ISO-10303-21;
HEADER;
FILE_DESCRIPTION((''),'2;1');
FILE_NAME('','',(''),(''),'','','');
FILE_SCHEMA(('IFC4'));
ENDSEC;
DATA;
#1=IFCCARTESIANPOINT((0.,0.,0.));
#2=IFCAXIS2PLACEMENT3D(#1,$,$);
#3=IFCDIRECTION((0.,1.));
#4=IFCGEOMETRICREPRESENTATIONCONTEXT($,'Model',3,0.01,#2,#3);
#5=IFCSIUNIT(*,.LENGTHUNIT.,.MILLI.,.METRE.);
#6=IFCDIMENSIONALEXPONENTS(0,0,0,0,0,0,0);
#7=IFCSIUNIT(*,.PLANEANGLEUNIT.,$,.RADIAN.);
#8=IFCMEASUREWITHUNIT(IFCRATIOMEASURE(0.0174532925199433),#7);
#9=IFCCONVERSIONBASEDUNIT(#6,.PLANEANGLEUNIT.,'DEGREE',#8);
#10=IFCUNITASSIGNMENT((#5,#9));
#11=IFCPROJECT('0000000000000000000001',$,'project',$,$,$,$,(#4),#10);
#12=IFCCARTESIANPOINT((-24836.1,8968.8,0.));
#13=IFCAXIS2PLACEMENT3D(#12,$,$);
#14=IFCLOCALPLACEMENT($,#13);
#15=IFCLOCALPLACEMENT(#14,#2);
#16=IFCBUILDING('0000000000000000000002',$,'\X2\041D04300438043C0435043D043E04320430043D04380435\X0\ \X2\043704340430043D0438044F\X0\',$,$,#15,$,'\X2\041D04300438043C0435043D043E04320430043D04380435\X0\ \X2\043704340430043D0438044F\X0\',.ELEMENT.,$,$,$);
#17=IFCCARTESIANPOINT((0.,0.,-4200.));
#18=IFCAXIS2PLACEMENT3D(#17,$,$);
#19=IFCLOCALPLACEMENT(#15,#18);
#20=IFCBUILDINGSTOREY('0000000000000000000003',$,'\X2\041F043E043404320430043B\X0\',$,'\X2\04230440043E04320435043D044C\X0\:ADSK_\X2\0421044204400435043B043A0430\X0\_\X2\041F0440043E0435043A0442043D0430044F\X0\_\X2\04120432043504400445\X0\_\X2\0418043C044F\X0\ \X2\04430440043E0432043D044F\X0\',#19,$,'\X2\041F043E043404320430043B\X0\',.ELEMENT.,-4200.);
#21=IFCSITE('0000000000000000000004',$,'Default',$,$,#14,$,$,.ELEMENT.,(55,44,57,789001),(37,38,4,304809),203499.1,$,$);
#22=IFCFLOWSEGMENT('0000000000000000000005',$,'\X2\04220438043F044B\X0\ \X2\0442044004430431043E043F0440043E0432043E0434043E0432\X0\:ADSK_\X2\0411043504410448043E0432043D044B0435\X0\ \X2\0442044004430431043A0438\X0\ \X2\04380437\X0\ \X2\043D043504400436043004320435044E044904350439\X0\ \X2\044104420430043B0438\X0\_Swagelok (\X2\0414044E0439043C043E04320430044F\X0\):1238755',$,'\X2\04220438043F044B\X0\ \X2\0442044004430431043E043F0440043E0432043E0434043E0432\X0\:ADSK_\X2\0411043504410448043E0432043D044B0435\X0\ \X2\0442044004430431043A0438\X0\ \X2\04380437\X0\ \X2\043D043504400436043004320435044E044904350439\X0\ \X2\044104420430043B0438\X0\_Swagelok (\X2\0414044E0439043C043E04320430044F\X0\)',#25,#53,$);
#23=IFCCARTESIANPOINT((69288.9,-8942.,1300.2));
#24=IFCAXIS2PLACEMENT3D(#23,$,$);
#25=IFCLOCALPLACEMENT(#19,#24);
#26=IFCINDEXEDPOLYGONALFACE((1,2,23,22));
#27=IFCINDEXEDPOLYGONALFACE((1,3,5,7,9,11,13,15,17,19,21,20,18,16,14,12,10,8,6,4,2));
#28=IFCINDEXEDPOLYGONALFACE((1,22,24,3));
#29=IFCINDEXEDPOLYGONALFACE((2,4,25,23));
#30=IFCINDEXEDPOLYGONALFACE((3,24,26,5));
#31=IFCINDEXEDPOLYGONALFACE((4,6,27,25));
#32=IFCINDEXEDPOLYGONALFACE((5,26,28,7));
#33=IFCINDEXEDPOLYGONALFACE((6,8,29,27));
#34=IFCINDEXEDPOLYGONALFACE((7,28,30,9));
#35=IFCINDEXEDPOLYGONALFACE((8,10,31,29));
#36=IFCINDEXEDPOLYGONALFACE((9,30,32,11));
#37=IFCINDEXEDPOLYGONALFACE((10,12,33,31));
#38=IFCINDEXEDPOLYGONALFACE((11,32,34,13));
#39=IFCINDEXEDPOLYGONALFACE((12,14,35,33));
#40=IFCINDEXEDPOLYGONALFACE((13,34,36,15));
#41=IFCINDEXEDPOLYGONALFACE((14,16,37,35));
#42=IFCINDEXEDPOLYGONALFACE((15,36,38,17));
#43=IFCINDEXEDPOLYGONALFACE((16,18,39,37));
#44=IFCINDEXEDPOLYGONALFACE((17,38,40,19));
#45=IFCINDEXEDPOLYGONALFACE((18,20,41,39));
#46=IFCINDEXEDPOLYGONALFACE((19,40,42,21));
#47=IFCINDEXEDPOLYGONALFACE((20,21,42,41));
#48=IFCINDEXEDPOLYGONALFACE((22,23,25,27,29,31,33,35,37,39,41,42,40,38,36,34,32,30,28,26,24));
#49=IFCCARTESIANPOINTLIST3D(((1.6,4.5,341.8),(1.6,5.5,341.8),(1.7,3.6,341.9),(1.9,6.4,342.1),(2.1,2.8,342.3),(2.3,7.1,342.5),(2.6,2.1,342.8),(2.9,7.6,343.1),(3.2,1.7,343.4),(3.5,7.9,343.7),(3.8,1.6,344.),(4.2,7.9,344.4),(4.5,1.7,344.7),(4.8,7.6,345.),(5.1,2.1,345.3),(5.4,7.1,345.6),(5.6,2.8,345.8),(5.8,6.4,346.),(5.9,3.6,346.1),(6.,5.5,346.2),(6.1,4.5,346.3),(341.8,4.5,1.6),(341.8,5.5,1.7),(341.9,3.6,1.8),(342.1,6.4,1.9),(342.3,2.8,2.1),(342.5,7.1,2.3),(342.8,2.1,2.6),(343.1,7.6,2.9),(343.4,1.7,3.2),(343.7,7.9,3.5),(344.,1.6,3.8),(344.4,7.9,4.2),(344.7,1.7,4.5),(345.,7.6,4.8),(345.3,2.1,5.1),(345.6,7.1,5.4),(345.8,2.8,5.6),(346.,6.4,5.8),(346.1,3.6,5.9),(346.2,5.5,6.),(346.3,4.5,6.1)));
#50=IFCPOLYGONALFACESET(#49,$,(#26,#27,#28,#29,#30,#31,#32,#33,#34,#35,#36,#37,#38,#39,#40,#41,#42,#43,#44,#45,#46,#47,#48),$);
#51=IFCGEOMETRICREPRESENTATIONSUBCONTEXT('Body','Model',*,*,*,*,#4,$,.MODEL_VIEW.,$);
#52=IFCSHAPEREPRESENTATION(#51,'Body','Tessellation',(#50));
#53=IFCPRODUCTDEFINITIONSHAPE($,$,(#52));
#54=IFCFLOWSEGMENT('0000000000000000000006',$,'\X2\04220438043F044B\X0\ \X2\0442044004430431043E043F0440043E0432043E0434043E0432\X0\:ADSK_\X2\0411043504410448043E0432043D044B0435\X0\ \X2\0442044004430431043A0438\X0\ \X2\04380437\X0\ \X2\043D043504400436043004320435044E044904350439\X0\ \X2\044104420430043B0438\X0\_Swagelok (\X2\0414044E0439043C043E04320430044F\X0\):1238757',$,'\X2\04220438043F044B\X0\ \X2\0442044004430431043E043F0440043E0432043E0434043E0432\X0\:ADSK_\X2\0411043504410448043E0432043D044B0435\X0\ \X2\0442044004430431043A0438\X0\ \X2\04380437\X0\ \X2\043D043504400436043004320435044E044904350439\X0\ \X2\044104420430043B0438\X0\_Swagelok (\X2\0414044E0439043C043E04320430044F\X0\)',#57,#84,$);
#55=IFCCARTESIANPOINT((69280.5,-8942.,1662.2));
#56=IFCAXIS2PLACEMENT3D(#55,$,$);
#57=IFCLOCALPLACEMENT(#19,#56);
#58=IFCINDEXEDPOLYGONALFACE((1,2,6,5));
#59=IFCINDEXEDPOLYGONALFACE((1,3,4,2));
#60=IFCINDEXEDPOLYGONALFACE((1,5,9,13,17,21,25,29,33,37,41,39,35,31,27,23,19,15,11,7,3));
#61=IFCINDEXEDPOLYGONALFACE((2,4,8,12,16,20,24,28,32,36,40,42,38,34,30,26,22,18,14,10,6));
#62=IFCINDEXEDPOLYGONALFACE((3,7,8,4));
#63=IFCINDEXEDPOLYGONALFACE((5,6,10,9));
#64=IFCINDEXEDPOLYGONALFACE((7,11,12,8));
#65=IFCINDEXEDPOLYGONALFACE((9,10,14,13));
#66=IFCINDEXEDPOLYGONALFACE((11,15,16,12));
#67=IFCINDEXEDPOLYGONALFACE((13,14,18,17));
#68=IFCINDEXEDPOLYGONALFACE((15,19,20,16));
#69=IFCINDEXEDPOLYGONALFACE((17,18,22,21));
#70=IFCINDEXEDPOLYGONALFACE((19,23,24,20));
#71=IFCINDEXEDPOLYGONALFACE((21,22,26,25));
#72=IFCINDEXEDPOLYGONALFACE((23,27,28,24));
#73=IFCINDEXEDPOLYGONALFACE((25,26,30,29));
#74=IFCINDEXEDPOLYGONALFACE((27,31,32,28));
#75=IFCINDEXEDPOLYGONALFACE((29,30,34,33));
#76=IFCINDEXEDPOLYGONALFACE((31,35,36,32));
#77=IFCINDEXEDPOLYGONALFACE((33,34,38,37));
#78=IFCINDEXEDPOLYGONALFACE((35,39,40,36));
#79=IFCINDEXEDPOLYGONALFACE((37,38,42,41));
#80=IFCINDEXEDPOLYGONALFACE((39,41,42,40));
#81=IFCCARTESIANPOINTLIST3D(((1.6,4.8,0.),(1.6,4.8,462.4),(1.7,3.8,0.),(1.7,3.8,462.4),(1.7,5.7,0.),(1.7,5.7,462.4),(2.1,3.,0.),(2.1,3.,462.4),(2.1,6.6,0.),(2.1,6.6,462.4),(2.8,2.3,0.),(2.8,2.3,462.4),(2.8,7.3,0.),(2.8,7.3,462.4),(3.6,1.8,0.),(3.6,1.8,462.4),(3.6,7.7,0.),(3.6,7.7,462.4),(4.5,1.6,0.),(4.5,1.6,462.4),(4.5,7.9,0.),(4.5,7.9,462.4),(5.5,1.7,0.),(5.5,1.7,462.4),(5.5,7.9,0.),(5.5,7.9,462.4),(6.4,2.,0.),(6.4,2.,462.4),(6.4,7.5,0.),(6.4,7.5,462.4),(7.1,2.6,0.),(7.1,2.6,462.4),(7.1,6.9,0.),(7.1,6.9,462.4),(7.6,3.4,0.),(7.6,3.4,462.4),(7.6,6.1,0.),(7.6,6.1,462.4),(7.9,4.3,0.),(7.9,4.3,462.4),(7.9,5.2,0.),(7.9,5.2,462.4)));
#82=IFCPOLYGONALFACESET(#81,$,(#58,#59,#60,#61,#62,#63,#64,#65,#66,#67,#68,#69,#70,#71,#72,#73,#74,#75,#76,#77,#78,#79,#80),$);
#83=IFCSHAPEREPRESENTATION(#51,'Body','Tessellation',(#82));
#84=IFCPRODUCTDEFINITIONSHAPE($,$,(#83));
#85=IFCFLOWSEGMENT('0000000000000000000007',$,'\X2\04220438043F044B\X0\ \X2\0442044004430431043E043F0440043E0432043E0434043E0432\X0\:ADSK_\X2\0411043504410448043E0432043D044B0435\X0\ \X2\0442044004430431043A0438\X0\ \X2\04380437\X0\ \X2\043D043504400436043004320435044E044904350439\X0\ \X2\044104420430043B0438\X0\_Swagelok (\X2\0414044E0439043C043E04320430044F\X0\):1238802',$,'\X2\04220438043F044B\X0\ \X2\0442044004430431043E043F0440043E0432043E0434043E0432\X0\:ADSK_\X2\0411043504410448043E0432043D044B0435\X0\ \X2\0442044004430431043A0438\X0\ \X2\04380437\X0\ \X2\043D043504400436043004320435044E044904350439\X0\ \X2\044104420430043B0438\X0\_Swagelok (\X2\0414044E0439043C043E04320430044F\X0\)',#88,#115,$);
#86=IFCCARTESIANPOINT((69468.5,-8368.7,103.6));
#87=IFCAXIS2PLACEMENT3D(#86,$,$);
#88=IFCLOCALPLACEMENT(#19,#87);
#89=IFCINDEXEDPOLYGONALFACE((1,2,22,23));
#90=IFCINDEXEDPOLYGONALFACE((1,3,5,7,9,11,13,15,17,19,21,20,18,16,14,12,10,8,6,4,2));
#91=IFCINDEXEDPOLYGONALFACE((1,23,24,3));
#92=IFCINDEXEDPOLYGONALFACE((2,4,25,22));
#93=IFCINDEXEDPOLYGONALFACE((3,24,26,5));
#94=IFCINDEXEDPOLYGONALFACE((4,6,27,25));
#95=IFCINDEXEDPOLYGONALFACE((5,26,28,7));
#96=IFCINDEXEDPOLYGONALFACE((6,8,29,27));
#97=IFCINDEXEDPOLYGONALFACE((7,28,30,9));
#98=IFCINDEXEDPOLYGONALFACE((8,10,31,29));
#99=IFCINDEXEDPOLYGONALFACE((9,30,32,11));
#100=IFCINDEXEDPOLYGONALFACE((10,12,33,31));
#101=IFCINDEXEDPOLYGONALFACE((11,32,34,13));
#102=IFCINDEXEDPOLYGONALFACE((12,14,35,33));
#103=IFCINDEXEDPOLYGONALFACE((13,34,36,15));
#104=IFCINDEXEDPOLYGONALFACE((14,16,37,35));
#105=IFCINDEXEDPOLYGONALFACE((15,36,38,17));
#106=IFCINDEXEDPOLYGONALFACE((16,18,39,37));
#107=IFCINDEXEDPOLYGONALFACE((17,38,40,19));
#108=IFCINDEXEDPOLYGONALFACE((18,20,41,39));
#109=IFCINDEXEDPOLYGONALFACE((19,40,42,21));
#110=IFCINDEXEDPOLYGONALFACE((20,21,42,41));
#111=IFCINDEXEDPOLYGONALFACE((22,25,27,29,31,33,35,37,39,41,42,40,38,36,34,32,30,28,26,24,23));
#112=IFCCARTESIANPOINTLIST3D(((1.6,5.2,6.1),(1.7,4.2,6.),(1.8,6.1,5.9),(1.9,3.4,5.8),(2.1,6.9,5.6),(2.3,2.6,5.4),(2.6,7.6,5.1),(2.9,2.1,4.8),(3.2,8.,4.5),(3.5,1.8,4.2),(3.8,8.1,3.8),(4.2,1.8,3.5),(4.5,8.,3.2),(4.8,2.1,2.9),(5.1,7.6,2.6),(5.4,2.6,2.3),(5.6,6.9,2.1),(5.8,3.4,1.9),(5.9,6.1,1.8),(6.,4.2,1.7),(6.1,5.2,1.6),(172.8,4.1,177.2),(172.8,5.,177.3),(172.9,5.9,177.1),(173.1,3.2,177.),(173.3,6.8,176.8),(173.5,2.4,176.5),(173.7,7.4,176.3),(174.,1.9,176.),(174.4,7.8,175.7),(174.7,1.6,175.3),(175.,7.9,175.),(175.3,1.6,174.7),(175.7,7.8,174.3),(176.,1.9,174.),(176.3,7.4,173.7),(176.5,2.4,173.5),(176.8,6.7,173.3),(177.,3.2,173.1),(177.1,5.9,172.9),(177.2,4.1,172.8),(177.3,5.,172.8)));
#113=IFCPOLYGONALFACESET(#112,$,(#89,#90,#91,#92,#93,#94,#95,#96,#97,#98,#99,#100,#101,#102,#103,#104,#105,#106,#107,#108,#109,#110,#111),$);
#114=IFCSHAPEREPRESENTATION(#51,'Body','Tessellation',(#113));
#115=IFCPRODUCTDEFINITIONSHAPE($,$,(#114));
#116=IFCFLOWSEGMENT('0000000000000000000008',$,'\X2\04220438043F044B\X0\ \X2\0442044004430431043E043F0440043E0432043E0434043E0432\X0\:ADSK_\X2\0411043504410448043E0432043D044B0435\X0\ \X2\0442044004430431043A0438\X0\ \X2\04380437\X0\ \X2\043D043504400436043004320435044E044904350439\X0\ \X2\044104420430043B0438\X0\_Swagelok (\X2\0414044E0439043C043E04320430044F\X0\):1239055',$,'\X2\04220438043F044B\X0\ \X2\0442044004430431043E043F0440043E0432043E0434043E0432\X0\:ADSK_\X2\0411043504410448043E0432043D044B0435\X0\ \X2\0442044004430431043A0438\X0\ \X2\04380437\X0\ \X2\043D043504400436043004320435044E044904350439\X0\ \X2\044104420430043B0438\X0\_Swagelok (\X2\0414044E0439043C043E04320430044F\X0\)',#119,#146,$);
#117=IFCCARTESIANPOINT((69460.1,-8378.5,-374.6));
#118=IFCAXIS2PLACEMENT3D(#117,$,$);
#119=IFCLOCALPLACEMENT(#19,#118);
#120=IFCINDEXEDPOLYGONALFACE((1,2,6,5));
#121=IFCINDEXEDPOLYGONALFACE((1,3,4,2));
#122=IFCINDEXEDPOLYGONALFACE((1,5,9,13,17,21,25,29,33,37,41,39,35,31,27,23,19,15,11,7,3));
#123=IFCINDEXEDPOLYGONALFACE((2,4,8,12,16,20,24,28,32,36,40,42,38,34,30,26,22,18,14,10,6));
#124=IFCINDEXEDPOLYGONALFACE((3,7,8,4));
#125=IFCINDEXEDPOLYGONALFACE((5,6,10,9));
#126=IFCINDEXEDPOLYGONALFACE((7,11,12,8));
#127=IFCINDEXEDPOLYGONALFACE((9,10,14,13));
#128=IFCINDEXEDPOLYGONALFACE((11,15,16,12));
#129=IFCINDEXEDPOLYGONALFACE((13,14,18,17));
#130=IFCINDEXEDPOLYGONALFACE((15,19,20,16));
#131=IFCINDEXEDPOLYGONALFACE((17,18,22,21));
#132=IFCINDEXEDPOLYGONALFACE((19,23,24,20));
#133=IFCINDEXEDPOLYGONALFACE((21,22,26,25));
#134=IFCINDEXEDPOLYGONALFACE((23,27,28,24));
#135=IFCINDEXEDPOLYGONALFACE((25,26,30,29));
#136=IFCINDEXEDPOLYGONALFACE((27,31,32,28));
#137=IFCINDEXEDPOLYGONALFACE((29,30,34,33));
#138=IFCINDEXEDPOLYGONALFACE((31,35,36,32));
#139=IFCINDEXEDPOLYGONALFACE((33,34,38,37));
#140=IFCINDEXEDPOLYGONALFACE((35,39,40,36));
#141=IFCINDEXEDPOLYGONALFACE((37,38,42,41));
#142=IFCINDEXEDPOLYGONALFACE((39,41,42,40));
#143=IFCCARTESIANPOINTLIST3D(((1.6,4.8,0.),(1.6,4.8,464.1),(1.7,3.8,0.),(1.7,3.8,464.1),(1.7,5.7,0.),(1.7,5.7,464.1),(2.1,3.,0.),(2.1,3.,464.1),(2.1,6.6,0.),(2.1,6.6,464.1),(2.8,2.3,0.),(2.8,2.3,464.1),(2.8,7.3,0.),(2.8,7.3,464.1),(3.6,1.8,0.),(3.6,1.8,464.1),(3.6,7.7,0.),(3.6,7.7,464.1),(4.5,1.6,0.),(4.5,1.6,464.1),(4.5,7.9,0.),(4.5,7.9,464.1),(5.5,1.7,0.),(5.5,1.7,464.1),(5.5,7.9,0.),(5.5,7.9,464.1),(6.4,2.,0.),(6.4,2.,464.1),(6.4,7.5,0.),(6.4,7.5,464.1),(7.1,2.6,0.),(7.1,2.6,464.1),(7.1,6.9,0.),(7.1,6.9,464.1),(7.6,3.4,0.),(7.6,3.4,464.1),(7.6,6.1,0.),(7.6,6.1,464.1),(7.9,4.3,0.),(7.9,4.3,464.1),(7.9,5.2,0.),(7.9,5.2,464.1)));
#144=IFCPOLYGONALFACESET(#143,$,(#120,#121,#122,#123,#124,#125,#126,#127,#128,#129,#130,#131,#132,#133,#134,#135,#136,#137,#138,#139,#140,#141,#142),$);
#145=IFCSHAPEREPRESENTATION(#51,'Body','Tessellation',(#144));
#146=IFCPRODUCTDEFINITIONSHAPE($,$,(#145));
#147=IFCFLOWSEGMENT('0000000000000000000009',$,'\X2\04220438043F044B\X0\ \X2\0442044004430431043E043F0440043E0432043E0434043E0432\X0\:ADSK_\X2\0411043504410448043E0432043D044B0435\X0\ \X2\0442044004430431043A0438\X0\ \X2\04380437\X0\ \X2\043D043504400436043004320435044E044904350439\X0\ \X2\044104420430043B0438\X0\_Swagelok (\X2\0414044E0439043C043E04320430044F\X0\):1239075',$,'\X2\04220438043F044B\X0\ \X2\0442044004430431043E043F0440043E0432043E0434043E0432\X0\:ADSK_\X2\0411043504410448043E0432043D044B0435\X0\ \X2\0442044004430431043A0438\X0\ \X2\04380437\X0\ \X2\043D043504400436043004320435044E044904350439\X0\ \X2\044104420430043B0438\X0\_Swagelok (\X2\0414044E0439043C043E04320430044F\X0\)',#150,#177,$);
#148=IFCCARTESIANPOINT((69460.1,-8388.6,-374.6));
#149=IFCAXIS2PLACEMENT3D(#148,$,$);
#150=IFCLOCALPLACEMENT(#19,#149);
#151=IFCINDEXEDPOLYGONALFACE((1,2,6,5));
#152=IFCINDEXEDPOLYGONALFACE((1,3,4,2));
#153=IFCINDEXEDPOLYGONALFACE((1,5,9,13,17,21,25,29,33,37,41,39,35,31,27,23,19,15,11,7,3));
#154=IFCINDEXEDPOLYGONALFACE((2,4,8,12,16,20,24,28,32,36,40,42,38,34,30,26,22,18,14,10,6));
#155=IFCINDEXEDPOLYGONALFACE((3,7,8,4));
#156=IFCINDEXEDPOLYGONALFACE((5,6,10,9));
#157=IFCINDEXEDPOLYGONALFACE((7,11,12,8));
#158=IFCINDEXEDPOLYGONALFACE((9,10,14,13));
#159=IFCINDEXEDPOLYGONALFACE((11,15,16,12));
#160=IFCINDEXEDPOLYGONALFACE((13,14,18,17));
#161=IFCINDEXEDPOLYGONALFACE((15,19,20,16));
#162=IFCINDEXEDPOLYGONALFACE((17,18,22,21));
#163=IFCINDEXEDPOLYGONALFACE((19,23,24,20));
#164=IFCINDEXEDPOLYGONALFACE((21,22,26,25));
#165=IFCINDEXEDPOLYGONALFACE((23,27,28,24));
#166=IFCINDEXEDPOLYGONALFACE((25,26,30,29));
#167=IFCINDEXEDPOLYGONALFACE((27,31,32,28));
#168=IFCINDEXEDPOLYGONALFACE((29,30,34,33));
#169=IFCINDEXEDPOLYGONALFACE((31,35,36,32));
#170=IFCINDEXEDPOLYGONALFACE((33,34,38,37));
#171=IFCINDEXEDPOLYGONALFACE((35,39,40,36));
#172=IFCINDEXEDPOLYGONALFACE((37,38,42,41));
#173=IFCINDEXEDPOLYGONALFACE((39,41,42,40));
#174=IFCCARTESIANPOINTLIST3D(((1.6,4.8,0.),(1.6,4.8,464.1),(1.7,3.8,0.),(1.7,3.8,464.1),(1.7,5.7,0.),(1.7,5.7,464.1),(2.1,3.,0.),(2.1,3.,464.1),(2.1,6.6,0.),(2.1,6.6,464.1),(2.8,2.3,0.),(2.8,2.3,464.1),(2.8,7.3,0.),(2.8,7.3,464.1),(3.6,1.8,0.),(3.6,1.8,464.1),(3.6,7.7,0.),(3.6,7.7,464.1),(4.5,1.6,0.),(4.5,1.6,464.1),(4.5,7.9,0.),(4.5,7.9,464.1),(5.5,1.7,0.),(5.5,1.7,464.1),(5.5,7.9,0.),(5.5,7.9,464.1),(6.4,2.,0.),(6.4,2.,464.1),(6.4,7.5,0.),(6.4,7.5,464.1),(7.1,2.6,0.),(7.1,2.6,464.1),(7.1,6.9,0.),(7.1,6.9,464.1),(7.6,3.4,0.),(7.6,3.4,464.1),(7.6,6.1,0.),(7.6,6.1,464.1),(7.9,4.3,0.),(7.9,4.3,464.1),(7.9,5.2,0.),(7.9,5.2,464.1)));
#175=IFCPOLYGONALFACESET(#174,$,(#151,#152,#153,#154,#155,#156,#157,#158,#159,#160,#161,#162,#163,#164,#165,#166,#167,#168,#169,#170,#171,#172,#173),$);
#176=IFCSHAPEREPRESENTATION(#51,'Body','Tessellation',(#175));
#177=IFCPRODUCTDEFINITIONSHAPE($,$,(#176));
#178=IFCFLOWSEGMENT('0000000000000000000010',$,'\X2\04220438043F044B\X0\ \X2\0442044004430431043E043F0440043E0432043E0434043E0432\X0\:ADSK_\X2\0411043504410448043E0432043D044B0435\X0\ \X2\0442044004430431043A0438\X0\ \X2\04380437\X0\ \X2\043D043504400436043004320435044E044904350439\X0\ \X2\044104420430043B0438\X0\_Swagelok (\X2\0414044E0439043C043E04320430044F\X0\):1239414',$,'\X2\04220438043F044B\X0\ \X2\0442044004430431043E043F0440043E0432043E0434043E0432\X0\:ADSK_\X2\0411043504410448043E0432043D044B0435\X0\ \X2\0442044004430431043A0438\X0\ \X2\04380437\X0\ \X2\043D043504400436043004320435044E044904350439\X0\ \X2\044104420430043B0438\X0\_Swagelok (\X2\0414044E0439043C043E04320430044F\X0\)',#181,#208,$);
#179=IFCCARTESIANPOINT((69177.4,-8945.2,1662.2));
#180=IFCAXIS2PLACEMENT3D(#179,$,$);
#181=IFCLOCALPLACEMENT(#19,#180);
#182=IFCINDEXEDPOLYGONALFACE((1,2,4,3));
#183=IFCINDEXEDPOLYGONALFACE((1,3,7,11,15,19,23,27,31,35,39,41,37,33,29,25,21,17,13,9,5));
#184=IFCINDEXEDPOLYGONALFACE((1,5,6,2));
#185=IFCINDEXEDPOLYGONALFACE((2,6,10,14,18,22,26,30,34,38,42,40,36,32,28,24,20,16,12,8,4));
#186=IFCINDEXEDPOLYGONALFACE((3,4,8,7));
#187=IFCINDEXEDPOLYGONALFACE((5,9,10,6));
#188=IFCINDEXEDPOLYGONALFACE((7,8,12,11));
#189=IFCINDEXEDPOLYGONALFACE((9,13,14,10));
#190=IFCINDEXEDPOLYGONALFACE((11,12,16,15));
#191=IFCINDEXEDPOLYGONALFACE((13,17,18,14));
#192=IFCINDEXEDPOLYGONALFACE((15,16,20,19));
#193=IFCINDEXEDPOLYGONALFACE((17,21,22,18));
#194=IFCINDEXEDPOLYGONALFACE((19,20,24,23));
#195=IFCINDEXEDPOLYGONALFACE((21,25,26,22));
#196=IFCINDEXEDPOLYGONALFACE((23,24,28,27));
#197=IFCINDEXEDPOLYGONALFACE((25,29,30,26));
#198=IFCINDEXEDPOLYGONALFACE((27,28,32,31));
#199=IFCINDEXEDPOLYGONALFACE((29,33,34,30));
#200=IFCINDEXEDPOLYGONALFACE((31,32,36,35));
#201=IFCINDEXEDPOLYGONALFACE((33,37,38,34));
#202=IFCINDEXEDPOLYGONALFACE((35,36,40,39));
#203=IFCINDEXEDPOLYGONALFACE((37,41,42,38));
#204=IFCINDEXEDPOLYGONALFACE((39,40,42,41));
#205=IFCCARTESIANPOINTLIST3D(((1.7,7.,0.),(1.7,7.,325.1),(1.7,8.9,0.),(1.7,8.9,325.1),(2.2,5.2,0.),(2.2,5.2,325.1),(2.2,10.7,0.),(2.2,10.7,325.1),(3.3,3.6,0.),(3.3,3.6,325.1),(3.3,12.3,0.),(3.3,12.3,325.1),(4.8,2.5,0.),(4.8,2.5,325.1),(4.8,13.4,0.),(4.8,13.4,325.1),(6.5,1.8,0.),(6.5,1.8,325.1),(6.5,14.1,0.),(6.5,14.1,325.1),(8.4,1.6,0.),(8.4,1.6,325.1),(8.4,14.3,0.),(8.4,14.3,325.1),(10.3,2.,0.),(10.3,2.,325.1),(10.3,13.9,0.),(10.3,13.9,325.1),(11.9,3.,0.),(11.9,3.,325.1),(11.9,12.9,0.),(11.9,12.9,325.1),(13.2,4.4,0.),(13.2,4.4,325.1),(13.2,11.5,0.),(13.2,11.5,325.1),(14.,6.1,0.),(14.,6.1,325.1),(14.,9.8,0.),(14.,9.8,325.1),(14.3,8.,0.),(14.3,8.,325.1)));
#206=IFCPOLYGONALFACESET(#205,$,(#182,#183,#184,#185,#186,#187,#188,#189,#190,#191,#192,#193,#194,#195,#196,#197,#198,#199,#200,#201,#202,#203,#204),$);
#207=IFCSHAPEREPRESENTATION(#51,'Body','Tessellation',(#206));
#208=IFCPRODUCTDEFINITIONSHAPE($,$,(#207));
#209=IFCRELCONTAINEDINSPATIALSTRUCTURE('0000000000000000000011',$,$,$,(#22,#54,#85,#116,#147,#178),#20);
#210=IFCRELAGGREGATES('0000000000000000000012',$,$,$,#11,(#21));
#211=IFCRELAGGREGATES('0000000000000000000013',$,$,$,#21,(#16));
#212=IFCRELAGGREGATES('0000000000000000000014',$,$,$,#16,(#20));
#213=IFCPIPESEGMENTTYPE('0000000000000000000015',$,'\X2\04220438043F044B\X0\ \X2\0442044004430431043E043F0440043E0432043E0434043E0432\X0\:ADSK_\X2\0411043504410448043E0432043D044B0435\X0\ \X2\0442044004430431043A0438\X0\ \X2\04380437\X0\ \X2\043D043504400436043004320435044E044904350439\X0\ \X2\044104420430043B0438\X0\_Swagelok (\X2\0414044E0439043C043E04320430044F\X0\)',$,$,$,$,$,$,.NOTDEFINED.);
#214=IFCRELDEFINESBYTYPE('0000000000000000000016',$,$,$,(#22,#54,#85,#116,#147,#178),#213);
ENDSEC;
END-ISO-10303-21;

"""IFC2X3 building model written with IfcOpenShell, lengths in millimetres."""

from ifc_helpers import new_model, entity, si_unit, converted_unit, direction, frame, origin, origin_2d_with_axis, place, context, subcontext, project, spatial, circle, extrude, type_object, element, save


model = new_model("IFC2X3")

# Units and contexts
model_context = context("Model", 3, precision=0.01, world=origin(), true_north=direction((0.0, 1.0)))
body_context = subcontext(model_context, "Body", "Model", "MODEL_VIEW")
ifc_project = project(units=[si_unit("LENGTHUNIT", "METRE", prefix="MILLI"), converted_unit("PLANEANGLEUNIT", "DEGREE", entity("IfcRatioMeasure", 0.0174532925199433), si_unit("PLANEANGLEUNIT", "RADIAN"), dimensions=[0, 0, 0, 0, 0, 0, 0])], contexts=[model_context])

# Site, building, storey
site_placement = place(None, frame((-24836.1, 8968.8, 0.0)))
site = spatial("IfcSite", under=ifc_project, at=site_placement, Name="Default", CompositionType="ELEMENT", RefLatitude=(55, 44, 57, 789001), RefLongitude=(37, 38, 4, 304809), RefElevation=203499.1)
building_placement = place(site_placement, origin())
building = spatial("IfcBuilding", under=site, at=building_placement, Name="Наименование здания", LongName="Наименование здания", CompositionType="ELEMENT")
storey_placement = place(building_placement, frame((0.0, 0.0, -4200.0)))
storey = spatial("IfcBuildingStorey", under=building, at=storey_placement, Name="Подвал", ObjectType="Уровень:ADSK_Стрелка_Проектная_Вверх_Имя уровня", LongName="Подвал", CompositionType="ELEMENT", Elevation=-4200.0)

# Flow segments
pipe_segment_type = type_object("IfcPipeSegmentType", Name="Типы трубопроводов:ADSK_Бесшовные трубки из нержавеющей стали_Swagelok (Дюймовая)", PredefinedType="NOTDEFINED")
flow_segment_1_placement = place(storey_placement, frame((69288.9, -8942.0, 1300.2)))
element("IfcFlowSegment", 1, at=flow_segment_1_placement, inside=storey, type_object=pipe_segment_type, Name="Типы трубопроводов:ADSK_Бесшовные трубки из нержавеющей стали_Swagelok (Дюймовая):1238755", ObjectType="Типы трубопроводов:ADSK_Бесшовные трубки из нержавеющей стали_Swagelok (Дюймовая)", context=body_context, shape_type="SweptSolid", body=[
    extrude(circle(Radius=3.2, at=origin_2d_with_axis()), frame((344.0, 4.8, 3.8), z_axis=(-0.707107, 0.0, 0.707107), x_axis=(0.0, -1.0, 0.0)), (0.0, 0.0, 1.0), 481.1),
])
flow_segment_2_placement = place(storey_placement, frame((69280.5, -8942.0, 1662.2)))
element("IfcFlowSegment", 2, at=flow_segment_2_placement, inside=storey, type_object=pipe_segment_type, Name="Типы трубопроводов:ADSK_Бесшовные трубки из нержавеющей стали_Swagelok (Дюймовая):1238757", ObjectType="Типы трубопроводов:ADSK_Бесшовные трубки из нержавеющей стали_Swagelok (Дюймовая)", context=body_context, shape_type="SweptSolid", body=[
    extrude(circle(Radius=3.2, at=origin_2d_with_axis()), frame((4.8, 4.8, 0.0), z_axis=(0.0, 0.0, 1.0), x_axis=(-1.0, 0.0, 0.0)), (0.0, 0.0, 1.0), 462.4),
])
flow_segment_3_placement = place(storey_placement, frame((69468.5, -8368.7, 103.6)))
element("IfcFlowSegment", 3, at=flow_segment_3_placement, inside=storey, type_object=pipe_segment_type, Name="Типы трубопроводов:ADSK_Бесшовные трубки из нержавеющей стали_Swagelok (Дюймовая):1238802", ObjectType="Типы трубопроводов:ADSK_Бесшовные трубки из нержавеющей стали_Swagelok (Дюймовая)", context=body_context, shape_type="SweptSolid", body=[
    extrude(circle(Radius=3.2, at=origin_2d_with_axis()), frame((3.8, 5.0, 3.8), z_axis=(0.707107, -0.000749, 0.707107), x_axis=(0.001059, 0.999999, 0.0)), (0.0, 0.0, 1.0), 242.1),
])
flow_segment_4_placement = place(storey_placement, frame((69460.1, -8378.5, -374.6)))
element("IfcFlowSegment", 4, at=flow_segment_4_placement, inside=storey, type_object=pipe_segment_type, Name="Типы трубопроводов:ADSK_Бесшовные трубки из нержавеющей стали_Swagelok (Дюймовая):1239055", ObjectType="Типы трубопроводов:ADSK_Бесшовные трубки из нержавеющей стали_Swagelok (Дюймовая)", context=body_context, shape_type="SweptSolid", body=[
    extrude(circle(Radius=3.2, at=origin_2d_with_axis()), frame((4.8, 4.8, 0.0), z_axis=(0.0, 0.0, 1.0), x_axis=(-1.0, 0.0, 0.0)), (0.0, 0.0, 1.0), 464.1),
])
flow_segment_5_placement = place(storey_placement, frame((69460.1, -8388.6, -374.6)))
element("IfcFlowSegment", 5, at=flow_segment_5_placement, inside=storey, type_object=pipe_segment_type, Name="Типы трубопроводов:ADSK_Бесшовные трубки из нержавеющей стали_Swagelok (Дюймовая):1239075", ObjectType="Типы трубопроводов:ADSK_Бесшовные трубки из нержавеющей стали_Swagelok (Дюймовая)", context=body_context, shape_type="SweptSolid", body=[
    extrude(circle(Radius=3.2, at=origin_2d_with_axis()), frame((4.8, 4.8, 0.0), z_axis=(0.0, 0.0, 1.0), x_axis=(-1.0, 0.0, 0.0)), (0.0, 0.0, 1.0), 464.1),
])
flow_segment_6_placement = place(storey_placement, frame((69177.4, -8945.2, 1662.2)))
element("IfcFlowSegment", 6, at=flow_segment_6_placement, inside=storey, type_object=pipe_segment_type, Name="Типы трубопроводов:ADSK_Бесшовные трубки из нержавеющей стали_Swagelok (Дюймовая):1239414", ObjectType="Типы трубопроводов:ADSK_Бесшовные трубки из нержавеющей стали_Swagelok (Дюймовая)", context=body_context, shape_type="SweptSolid", body=[
    extrude(circle(Radius=6.3, at=origin_2d_with_axis()), frame((8.0, 8.0, 0.0)), (0.0, 0.0, 1.0), 325.1),
])

save(model, "model.ifc")
